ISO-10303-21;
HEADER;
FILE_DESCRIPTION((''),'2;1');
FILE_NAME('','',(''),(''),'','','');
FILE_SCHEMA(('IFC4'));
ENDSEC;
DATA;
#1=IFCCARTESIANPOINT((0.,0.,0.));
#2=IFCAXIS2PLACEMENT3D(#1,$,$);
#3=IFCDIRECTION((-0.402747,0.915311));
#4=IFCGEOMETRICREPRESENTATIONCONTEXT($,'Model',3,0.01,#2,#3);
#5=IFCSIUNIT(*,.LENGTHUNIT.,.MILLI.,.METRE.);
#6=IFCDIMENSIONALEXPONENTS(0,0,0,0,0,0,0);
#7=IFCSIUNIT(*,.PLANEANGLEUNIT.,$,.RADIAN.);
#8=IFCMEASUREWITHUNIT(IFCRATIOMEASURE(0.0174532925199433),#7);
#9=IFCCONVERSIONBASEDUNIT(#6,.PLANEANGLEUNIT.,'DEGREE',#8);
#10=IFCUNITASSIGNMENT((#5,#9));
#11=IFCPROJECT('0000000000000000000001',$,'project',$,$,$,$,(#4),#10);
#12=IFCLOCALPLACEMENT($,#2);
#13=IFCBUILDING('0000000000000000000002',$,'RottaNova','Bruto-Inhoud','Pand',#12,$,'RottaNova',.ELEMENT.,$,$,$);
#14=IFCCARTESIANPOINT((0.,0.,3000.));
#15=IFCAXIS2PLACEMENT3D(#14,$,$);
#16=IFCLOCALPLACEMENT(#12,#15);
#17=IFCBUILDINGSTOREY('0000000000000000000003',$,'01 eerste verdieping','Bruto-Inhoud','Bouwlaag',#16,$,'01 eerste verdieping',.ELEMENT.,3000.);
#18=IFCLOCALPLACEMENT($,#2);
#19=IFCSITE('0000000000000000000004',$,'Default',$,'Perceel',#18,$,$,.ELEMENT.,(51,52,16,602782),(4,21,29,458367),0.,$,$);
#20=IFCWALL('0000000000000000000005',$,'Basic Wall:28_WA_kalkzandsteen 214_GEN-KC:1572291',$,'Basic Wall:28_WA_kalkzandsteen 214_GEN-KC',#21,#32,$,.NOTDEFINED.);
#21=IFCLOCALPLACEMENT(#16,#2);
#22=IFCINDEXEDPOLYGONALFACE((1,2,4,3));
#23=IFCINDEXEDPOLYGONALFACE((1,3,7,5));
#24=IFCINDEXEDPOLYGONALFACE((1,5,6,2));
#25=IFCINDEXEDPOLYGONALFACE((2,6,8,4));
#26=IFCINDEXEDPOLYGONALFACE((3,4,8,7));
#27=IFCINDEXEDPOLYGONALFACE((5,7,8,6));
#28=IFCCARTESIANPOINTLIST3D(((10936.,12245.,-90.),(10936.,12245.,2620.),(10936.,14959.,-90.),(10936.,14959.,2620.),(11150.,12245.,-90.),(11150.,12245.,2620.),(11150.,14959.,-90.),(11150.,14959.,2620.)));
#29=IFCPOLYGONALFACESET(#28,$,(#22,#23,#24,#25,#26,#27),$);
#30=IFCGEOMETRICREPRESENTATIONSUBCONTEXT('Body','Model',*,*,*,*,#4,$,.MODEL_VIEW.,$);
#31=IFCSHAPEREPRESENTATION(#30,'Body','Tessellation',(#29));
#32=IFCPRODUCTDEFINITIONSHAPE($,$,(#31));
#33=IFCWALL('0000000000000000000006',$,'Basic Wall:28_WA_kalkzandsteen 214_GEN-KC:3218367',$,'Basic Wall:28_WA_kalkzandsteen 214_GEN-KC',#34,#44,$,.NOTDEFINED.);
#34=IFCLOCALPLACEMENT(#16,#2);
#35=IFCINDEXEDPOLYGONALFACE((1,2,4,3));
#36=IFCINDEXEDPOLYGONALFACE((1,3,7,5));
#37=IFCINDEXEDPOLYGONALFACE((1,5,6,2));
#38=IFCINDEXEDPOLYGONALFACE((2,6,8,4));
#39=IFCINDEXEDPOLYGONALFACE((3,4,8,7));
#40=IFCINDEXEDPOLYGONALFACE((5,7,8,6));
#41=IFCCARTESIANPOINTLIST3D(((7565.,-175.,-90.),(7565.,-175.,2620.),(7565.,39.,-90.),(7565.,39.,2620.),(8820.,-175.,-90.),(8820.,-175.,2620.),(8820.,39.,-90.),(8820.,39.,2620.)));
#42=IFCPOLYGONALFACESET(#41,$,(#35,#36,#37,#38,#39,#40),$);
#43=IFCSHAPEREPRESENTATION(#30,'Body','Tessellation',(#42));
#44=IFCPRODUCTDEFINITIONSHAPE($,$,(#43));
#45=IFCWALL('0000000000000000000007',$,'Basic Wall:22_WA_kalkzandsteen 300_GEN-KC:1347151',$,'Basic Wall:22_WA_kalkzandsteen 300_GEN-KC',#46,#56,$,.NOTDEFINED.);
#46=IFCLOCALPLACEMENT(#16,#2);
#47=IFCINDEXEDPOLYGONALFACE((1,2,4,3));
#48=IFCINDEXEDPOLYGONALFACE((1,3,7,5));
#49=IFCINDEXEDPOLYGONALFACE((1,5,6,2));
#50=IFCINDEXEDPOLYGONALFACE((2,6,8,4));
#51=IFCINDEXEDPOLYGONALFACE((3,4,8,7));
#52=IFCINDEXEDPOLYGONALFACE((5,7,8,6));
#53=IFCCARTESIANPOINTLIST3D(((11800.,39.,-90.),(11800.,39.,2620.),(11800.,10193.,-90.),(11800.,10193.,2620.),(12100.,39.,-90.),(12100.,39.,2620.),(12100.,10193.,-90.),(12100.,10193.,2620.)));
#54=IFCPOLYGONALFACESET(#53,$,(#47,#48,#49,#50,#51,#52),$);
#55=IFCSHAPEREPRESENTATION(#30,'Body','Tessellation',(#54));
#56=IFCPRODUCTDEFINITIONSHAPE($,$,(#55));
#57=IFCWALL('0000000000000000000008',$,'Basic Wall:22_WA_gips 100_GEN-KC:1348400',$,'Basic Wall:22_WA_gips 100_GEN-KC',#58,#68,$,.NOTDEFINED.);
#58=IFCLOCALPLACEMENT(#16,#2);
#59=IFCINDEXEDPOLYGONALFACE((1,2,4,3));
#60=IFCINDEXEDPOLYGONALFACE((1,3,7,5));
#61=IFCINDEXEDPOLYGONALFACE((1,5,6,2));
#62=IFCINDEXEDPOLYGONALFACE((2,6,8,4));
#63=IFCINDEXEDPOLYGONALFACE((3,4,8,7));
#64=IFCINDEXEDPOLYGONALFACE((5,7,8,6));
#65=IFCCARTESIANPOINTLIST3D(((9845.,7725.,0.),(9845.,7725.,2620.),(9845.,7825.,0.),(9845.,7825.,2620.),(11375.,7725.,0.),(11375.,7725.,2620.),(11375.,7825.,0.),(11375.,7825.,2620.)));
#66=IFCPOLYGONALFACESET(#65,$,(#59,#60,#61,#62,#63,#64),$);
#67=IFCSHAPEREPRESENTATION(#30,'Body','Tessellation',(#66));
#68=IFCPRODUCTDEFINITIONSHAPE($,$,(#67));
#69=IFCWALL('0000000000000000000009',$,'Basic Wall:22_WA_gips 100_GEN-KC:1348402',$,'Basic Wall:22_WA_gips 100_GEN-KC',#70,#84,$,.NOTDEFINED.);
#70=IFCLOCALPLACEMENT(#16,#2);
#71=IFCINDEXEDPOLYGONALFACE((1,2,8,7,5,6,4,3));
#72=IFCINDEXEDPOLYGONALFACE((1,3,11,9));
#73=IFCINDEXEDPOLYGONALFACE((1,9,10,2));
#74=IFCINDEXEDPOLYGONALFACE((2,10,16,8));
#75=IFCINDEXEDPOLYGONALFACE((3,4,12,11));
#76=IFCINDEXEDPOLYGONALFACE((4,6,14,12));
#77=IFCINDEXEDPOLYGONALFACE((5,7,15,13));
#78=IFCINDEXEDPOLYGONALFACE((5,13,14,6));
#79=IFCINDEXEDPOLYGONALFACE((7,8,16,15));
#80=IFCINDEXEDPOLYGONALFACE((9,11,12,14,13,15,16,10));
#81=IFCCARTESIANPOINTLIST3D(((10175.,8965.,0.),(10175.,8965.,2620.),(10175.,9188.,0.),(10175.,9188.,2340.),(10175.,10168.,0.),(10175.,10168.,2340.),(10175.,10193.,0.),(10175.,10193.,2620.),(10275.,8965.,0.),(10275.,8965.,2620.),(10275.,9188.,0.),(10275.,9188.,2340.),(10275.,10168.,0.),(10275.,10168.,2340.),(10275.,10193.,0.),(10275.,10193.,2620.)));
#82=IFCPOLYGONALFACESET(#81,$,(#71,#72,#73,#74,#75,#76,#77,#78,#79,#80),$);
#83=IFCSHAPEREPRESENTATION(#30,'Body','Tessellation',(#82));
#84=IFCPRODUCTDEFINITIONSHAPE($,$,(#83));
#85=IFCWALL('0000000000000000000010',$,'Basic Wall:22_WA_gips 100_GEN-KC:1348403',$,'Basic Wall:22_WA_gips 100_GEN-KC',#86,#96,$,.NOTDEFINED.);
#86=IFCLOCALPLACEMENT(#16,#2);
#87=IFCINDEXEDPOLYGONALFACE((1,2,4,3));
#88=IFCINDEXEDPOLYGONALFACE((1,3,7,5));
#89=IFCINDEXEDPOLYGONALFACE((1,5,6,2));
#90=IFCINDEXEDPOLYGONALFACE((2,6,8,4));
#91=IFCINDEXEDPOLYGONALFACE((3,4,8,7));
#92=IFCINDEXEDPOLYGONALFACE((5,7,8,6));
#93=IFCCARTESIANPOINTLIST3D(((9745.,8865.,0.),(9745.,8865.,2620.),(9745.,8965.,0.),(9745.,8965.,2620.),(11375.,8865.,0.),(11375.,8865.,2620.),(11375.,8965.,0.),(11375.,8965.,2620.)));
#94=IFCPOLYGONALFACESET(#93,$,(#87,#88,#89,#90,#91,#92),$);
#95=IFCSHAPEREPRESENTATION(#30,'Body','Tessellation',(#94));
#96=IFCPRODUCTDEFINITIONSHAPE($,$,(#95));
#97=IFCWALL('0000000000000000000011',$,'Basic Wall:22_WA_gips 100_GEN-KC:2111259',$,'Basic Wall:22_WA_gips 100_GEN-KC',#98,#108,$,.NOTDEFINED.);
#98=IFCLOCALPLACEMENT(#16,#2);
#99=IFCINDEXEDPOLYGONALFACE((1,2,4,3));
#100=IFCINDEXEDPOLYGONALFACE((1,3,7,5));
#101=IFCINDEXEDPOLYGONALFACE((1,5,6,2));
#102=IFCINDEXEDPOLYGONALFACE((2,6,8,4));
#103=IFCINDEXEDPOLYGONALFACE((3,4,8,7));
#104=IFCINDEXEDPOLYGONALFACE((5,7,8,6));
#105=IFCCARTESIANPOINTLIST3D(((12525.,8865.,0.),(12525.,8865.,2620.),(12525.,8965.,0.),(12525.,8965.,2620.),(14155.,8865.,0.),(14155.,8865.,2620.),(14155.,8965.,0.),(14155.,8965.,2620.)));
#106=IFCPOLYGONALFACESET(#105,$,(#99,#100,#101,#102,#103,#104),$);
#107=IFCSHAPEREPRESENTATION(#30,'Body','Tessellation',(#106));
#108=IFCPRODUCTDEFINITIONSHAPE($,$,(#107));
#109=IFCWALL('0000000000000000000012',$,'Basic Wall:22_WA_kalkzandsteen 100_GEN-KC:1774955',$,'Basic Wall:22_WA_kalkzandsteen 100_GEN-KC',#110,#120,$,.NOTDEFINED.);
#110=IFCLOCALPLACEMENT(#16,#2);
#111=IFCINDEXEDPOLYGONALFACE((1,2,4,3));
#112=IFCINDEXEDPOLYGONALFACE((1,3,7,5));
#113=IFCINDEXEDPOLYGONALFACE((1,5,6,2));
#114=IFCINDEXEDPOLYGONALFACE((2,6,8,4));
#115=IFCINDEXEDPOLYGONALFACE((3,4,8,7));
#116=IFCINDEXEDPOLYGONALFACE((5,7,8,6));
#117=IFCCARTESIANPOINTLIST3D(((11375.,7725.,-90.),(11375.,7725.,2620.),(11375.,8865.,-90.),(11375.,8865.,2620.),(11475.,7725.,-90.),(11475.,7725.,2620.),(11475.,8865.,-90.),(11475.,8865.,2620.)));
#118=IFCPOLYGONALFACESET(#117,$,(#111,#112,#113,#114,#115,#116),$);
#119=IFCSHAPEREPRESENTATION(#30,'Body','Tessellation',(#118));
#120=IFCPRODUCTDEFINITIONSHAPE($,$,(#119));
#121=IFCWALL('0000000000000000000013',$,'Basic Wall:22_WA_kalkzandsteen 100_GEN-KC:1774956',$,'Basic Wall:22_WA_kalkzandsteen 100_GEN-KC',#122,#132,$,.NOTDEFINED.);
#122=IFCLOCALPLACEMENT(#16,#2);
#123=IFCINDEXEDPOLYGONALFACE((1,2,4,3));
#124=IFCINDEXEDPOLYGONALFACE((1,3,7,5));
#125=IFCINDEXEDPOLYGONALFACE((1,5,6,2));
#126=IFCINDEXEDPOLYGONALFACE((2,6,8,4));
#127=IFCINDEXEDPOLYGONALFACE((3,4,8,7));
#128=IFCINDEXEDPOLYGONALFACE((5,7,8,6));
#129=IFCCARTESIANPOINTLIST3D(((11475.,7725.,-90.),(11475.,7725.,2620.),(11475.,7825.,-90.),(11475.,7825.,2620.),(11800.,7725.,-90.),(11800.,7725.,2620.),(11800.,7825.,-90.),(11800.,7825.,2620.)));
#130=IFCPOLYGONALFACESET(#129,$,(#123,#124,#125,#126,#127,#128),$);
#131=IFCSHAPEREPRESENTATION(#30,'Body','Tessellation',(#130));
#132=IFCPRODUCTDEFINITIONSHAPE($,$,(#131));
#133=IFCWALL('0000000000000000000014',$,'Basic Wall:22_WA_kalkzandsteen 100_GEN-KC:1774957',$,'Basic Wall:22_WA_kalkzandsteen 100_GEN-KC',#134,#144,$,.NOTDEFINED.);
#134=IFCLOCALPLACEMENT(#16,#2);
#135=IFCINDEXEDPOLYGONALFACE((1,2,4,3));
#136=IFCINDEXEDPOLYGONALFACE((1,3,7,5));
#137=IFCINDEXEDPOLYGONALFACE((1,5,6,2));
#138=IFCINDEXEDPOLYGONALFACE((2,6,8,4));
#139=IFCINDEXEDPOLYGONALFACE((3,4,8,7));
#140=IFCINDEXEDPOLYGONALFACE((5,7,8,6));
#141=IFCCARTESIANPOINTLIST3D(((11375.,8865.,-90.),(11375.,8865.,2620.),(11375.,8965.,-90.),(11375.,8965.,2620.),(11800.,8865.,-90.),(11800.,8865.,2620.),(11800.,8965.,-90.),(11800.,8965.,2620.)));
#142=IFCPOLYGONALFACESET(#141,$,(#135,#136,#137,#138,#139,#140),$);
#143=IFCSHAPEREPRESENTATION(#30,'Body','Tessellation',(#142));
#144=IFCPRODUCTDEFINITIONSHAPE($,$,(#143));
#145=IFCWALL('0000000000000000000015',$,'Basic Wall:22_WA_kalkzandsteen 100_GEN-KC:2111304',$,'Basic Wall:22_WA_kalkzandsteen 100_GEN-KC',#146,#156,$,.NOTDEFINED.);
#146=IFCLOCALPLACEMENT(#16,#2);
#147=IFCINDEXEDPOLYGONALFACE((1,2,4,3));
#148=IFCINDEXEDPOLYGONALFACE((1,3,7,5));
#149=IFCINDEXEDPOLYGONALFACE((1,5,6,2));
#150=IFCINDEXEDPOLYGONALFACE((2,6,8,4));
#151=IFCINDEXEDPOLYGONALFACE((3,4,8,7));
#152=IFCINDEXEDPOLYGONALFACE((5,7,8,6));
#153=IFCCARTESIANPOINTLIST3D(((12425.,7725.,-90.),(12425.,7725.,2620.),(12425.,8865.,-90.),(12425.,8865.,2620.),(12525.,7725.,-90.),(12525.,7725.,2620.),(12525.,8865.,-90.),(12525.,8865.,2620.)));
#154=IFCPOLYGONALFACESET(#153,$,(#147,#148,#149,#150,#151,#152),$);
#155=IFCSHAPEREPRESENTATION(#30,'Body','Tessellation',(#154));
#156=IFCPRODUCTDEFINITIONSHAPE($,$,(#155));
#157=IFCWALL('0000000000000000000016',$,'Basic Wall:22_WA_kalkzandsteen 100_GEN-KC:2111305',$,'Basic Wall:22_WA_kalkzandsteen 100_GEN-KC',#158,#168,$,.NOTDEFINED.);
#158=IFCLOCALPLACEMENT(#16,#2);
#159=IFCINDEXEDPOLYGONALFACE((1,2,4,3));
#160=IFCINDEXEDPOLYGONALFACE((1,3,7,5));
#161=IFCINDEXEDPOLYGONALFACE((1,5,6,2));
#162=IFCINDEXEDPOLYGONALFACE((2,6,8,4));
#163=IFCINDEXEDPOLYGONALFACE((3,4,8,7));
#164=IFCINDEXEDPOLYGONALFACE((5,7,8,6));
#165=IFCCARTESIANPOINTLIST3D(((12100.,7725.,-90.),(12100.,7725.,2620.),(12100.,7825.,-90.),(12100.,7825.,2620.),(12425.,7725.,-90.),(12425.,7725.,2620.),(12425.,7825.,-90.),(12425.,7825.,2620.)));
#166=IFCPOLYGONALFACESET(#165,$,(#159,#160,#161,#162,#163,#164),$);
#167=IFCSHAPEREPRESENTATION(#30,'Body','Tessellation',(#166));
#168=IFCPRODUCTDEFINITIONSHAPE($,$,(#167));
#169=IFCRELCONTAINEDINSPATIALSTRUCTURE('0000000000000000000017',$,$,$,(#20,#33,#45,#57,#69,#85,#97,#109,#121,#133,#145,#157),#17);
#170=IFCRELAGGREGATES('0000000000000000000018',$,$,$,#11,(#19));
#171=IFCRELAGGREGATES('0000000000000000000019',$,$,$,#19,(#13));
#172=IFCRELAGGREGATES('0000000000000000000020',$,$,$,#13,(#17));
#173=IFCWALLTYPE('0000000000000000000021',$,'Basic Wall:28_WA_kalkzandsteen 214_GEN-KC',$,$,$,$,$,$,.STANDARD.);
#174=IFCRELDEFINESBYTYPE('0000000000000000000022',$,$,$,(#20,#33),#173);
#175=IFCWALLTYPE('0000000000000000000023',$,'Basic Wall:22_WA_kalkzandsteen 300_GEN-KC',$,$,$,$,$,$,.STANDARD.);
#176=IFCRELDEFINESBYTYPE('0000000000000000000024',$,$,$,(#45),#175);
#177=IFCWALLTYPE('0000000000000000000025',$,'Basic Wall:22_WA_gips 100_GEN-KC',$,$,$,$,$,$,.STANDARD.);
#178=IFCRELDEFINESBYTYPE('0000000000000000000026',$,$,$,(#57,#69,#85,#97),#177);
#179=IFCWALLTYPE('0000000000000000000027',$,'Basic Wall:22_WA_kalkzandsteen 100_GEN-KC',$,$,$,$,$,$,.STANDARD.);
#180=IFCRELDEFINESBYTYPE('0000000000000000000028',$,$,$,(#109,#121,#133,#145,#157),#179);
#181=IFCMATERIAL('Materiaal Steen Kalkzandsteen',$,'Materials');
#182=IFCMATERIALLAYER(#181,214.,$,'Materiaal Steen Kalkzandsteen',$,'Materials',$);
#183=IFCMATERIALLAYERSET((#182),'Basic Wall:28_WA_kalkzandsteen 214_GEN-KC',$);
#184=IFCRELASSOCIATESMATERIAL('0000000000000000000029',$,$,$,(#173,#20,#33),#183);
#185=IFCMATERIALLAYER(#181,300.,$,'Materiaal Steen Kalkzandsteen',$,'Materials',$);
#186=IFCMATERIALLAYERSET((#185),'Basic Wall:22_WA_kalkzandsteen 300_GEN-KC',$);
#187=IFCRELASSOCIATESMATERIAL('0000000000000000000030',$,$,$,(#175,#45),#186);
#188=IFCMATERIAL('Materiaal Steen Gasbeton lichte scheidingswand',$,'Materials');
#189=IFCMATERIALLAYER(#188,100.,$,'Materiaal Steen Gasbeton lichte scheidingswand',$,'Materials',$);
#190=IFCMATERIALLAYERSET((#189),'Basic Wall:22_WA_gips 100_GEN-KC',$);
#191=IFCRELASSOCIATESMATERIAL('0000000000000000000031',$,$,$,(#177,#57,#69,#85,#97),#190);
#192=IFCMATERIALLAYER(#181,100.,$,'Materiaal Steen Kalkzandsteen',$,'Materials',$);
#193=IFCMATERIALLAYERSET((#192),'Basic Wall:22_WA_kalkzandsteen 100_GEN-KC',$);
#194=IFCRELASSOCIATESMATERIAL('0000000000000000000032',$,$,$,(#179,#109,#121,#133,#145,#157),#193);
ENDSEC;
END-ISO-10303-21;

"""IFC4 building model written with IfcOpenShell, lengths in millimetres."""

from ifc_helpers import new_model, entity, si_unit, converted_unit, direction, frame, frame_2d, origin, place, context, subcontext, project, spatial, rectangle, extrude, material, layer, layer_set, type_object, element, save


model = new_model("IFC4")

# Units and contexts
model_context = context("Model", 3, precision=0.01, world=origin(), true_north=direction((-0.402747, 0.915311)))
body_context = subcontext(model_context, "Body", "Model", "MODEL_VIEW")
ifc_project = project(units=[si_unit("LENGTHUNIT", "METRE", prefix="MILLI"), converted_unit("PLANEANGLEUNIT", "DEGREE", entity("IfcRatioMeasure", 0.0174532925199433), si_unit("PLANEANGLEUNIT", "RADIAN"), dimensions=[0, 0, 0, 0, 0, 0, 0])], contexts=[model_context])

# Site, building, storey
site_placement = place(None, origin())
site = spatial("IfcSite", under=ifc_project, at=site_placement, Name="Default", ObjectType="Perceel", CompositionType="ELEMENT", RefLatitude=(51, 52, 16, 602782), RefLongitude=(4, 21, 29, 458367), RefElevation=0.0)
building_placement = place(None, origin())
building = spatial("IfcBuilding", under=site, at=building_placement, Name="RottaNova", Description="Bruto-Inhoud", ObjectType="Pand", LongName="RottaNova", CompositionType="ELEMENT")
storey_placement = place(building_placement, frame((0.0, 0.0, 3000.0)))
storey = spatial("IfcBuildingStorey", under=building, at=storey_placement, Name="01 eerste verdieping", Description="Bruto-Inhoud", ObjectType="Bouwlaag", LongName="01 eerste verdieping", CompositionType="ELEMENT", Elevation=3000.0)

# Walls
ifc_material_1 = material(Name="Materiaal Steen Kalkzandsteen", Category="Materials")
ifc_layer_1 = layer(ifc_material_1, 214.0, Name="Materiaal Steen Kalkzandsteen", Category="Materials")
ifc_layer_set_1 = layer_set([ifc_layer_1], Name="Basic Wall:28_WA_kalkzandsteen 214_GEN-KC")
wall_type_1 = type_object("IfcWallType", Name="Basic Wall:28_WA_kalkzandsteen 214_GEN-KC", PredefinedType="STANDARD", material=ifc_layer_set_1)
wall_1_placement = place(storey_placement, frame((11043.0, 12245.0, -90.0), z_axis=(0.0, 0.0, 1.0), x_axis=(0.0, 1.0, 0.0)))
element("IfcWall", 1, at=wall_1_placement, inside=storey, type_object=wall_type_1, material=ifc_layer_set_1, Name="Basic Wall:28_WA_kalkzandsteen 214_GEN-KC:1572291", ObjectType="Basic Wall:28_WA_kalkzandsteen 214_GEN-KC", PredefinedType="NOTDEFINED", context=body_context, shape_type="SweptSolid", body=[
    extrude(rectangle(XDim=2714.0, YDim=214.0, at=frame_2d((1357.0, 0.0), x_axis=(-1.0, 0.0))), origin(), (0.0, 0.0, 1.0), 2710.0),
])
wall_2_placement = place(storey_placement, frame((8820.0, -68.0, -90.0), z_axis=(0.0, 0.0, 1.0), x_axis=(-1.0, 0.0, 0.0)))
element("IfcWall", 2, at=wall_2_placement, inside=storey, type_object=wall_type_1, material=ifc_layer_set_1, Name="Basic Wall:28_WA_kalkzandsteen 214_GEN-KC:3218367", ObjectType="Basic Wall:28_WA_kalkzandsteen 214_GEN-KC", PredefinedType="NOTDEFINED", context=body_context, shape_type="SweptSolid", body=[
    extrude(rectangle(XDim=1255.0, YDim=214.0, at=frame_2d((627.5, 0.0), x_axis=(-1.0, 0.0))), origin(), (0.0, 0.0, 1.0), 2710.0),
])
ifc_layer_2 = layer(ifc_material_1, 300.0, Name="Materiaal Steen Kalkzandsteen", Category="Materials")
ifc_layer_set_2 = layer_set([ifc_layer_2], Name="Basic Wall:22_WA_kalkzandsteen 300_GEN-KC")
wall_type_2 = type_object("IfcWallType", Name="Basic Wall:22_WA_kalkzandsteen 300_GEN-KC", PredefinedType="STANDARD", material=ifc_layer_set_2)
wall_3_placement = place(storey_placement, frame((11950.0, 39.0, -90.0), z_axis=(0.0, 0.0, 1.0), x_axis=(0.0, 1.0, 0.0)))
element("IfcWall", 3, at=wall_3_placement, inside=storey, type_object=wall_type_2, material=ifc_layer_set_2, Name="Basic Wall:22_WA_kalkzandsteen 300_GEN-KC:1347151", ObjectType="Basic Wall:22_WA_kalkzandsteen 300_GEN-KC", PredefinedType="NOTDEFINED", context=body_context, shape_type="SweptSolid", body=[
    extrude(rectangle(XDim=10154.0, YDim=300.0, at=frame_2d((5077.0, 0.0), x_axis=(-1.0, 0.0))), origin(), (0.0, 0.0, 1.0), 2710.0),
])
ifc_material_2 = material(Name="Materiaal Steen Gasbeton lichte scheidingswand", Category="Materials")
ifc_layer_3 = layer(ifc_material_2, 100.0, Name="Materiaal Steen Gasbeton lichte scheidingswand", Category="Materials")
ifc_layer_set_3 = layer_set([ifc_layer_3], Name="Basic Wall:22_WA_gips 100_GEN-KC")
wall_type_3 = type_object("IfcWallType", Name="Basic Wall:22_WA_gips 100_GEN-KC", PredefinedType="STANDARD", material=ifc_layer_set_3)
wall_4_placement = place(storey_placement, frame((9845.0, 7775.0, 0.0)))
element("IfcWall", 4, at=wall_4_placement, inside=storey, type_object=wall_type_3, material=ifc_layer_set_3, Name="Basic Wall:22_WA_gips 100_GEN-KC:1348400", ObjectType="Basic Wall:22_WA_gips 100_GEN-KC", PredefinedType="NOTDEFINED", context=body_context, shape_type="SweptSolid", body=[
    extrude(rectangle(XDim=1530.0, YDim=100.0, at=frame_2d((765.0, 0.0), x_axis=(-1.0, 0.0))), origin(), (0.0, 0.0, 1.0), 2620.0),
])

# Wall, opening
wall_5_placement = place(storey_placement, frame((10225.0, 8965.0, 0.0), z_axis=(0.0, 0.0, 1.0), x_axis=(0.0, 1.0, 0.0)))
wall_5 = element("IfcWall", 5, at=wall_5_placement, inside=storey, type_object=wall_type_3, material=ifc_layer_set_3, Name="Basic Wall:22_WA_gips 100_GEN-KC:1348402", ObjectType="Basic Wall:22_WA_gips 100_GEN-KC", PredefinedType="NOTDEFINED", context=body_context, shape_type="SweptSolid", body=[
    extrude(rectangle(XDim=1228.0, YDim=100.0, at=frame_2d((614.0, 0.0), x_axis=(1.0, 0.0))), origin(), (0.0, 0.0, 1.0), 2620.0),
])
opening_1_placement = place(wall_5_placement, frame((223.0, -50.0, -90.0)))
element("IfcOpeningElement", 6, at=opening_1_placement, cuts=wall_5, PredefinedType="OPENING", context=body_context, shape_type="SweptSolid", body=[
    extrude(rectangle(XDim=2430.0, YDim=980.0, at=frame_2d((1215.0, 490.0), x_axis=(1.0, 0.0))), frame((0.0, 0.0, 0.0), z_axis=(0.0, 1.0, 0.0), x_axis=(0.0, 0.0, 1.0)), (0.0, 0.0, 1.0), 100.0),
])

# Walls
wall_6_placement = place(storey_placement, frame((11375.0, 8915.0, 0.0), z_axis=(0.0, 0.0, 1.0), x_axis=(-1.0, 0.0, 0.0)))
element("IfcWall", 7, at=wall_6_placement, inside=storey, type_object=wall_type_3, material=ifc_layer_set_3, Name="Basic Wall:22_WA_gips 100_GEN-KC:1348403", ObjectType="Basic Wall:22_WA_gips 100_GEN-KC", PredefinedType="NOTDEFINED", context=body_context, shape_type="SweptSolid", body=[
    extrude(rectangle(XDim=1630.0, YDim=100.0, at=frame_2d((815.0, 0.0), x_axis=(-1.0, 0.0))), origin(), (0.0, 0.0, 1.0), 2620.0),
])
wall_7_placement = place(storey_placement, frame((12525.0, 8915.0, 0.0)))
element("IfcWall", 8, at=wall_7_placement, inside=storey, type_object=wall_type_3, material=ifc_layer_set_3, Name="Basic Wall:22_WA_gips 100_GEN-KC:2111259", ObjectType="Basic Wall:22_WA_gips 100_GEN-KC", PredefinedType="NOTDEFINED", context=body_context, shape_type="SweptSolid", body=[
    extrude(rectangle(XDim=1630.0, YDim=100.0, at=frame_2d((815.0, 0.0), x_axis=(-1.0, 0.0))), origin(), (0.0, 0.0, 1.0), 2620.0),
])
ifc_layer_4 = layer(ifc_material_1, 100.0, Name="Materiaal Steen Kalkzandsteen", Category="Materials")
ifc_layer_set_4 = layer_set([ifc_layer_4], Name="Basic Wall:22_WA_kalkzandsteen 100_GEN-KC")
wall_type_4 = type_object("IfcWallType", Name="Basic Wall:22_WA_kalkzandsteen 100_GEN-KC", PredefinedType="STANDARD", material=ifc_layer_set_4)
wall_8_placement = place(storey_placement, frame((11425.0, 8865.0, -90.0), z_axis=(0.0, 0.0, 1.0), x_axis=(0.0, -1.0, 0.0)))
element("IfcWall", 9, at=wall_8_placement, inside=storey, type_object=wall_type_4, material=ifc_layer_set_4, Name="Basic Wall:22_WA_kalkzandsteen 100_GEN-KC:1774955", ObjectType="Basic Wall:22_WA_kalkzandsteen 100_GEN-KC", PredefinedType="NOTDEFINED", context=body_context, shape_type="SweptSolid", body=[
    extrude(rectangle(XDim=1140.0, YDim=100.0, at=frame_2d((570.0, 0.0), x_axis=(-1.0, 0.0))), origin(), (0.0, 0.0, 1.0), 2710.0),
])
wall_9_placement = place(storey_placement, frame((11800.0, 7775.0, -90.0), z_axis=(0.0, 0.0, 1.0), x_axis=(-1.0, 0.0, 0.0)))
element("IfcWall", 10, at=wall_9_placement, inside=storey, type_object=wall_type_4, material=ifc_layer_set_4, Name="Basic Wall:22_WA_kalkzandsteen 100_GEN-KC:1774956", ObjectType="Basic Wall:22_WA_kalkzandsteen 100_GEN-KC", PredefinedType="NOTDEFINED", context=body_context, shape_type="SweptSolid", body=[
    extrude(rectangle(XDim=325.0, YDim=100.0, at=frame_2d((162.5, 0.0), x_axis=(-1.0, 0.0))), origin(), (0.0, 0.0, 1.0), 2710.0),
])
wall_10_placement = place(storey_placement, frame((11800.0, 8915.0, -90.0), z_axis=(0.0, 0.0, 1.0), x_axis=(-1.0, 0.0, 0.0)))
element("IfcWall", 11, at=wall_10_placement, inside=storey, type_object=wall_type_4, material=ifc_layer_set_4, Name="Basic Wall:22_WA_kalkzandsteen 100_GEN-KC:1774957", ObjectType="Basic Wall:22_WA_kalkzandsteen 100_GEN-KC", PredefinedType="NOTDEFINED", context=body_context, shape_type="SweptSolid", body=[
    extrude(rectangle(XDim=425.0, YDim=100.0, at=frame_2d((212.5, 0.0), x_axis=(-1.0, 0.0))), origin(), (0.0, 0.0, 1.0), 2710.0),
])
wall_11_placement = place(storey_placement, frame((12475.0, 8865.0, -90.0), z_axis=(0.0, 0.0, 1.0), x_axis=(0.0, -1.0, 0.0)))
element("IfcWall", 12, at=wall_11_placement, inside=storey, type_object=wall_type_4, material=ifc_layer_set_4, Name="Basic Wall:22_WA_kalkzandsteen 100_GEN-KC:2111304", ObjectType="Basic Wall:22_WA_kalkzandsteen 100_GEN-KC", PredefinedType="NOTDEFINED", context=body_context, shape_type="SweptSolid", body=[
    extrude(rectangle(XDim=1140.0, YDim=100.0, at=frame_2d((570.0, 0.0), x_axis=(-1.0, 0.0))), origin(), (0.0, 0.0, 1.0), 2710.0),
])
wall_12_placement = place(storey_placement, frame((12100.0, 7775.0, -90.0)))
element("IfcWall", 13, at=wall_12_placement, inside=storey, type_object=wall_type_4, material=ifc_layer_set_4, Name="Basic Wall:22_WA_kalkzandsteen 100_GEN-KC:2111305", ObjectType="Basic Wall:22_WA_kalkzandsteen 100_GEN-KC", PredefinedType="NOTDEFINED", context=body_context, shape_type="SweptSolid", body=[
    extrude(rectangle(XDim=325.0, YDim=100.0, at=frame_2d((162.5, 0.0), x_axis=(-1.0, 0.0))), origin(), (0.0, 0.0, 1.0), 2710.0),
])

save(model, "model.ifc")
